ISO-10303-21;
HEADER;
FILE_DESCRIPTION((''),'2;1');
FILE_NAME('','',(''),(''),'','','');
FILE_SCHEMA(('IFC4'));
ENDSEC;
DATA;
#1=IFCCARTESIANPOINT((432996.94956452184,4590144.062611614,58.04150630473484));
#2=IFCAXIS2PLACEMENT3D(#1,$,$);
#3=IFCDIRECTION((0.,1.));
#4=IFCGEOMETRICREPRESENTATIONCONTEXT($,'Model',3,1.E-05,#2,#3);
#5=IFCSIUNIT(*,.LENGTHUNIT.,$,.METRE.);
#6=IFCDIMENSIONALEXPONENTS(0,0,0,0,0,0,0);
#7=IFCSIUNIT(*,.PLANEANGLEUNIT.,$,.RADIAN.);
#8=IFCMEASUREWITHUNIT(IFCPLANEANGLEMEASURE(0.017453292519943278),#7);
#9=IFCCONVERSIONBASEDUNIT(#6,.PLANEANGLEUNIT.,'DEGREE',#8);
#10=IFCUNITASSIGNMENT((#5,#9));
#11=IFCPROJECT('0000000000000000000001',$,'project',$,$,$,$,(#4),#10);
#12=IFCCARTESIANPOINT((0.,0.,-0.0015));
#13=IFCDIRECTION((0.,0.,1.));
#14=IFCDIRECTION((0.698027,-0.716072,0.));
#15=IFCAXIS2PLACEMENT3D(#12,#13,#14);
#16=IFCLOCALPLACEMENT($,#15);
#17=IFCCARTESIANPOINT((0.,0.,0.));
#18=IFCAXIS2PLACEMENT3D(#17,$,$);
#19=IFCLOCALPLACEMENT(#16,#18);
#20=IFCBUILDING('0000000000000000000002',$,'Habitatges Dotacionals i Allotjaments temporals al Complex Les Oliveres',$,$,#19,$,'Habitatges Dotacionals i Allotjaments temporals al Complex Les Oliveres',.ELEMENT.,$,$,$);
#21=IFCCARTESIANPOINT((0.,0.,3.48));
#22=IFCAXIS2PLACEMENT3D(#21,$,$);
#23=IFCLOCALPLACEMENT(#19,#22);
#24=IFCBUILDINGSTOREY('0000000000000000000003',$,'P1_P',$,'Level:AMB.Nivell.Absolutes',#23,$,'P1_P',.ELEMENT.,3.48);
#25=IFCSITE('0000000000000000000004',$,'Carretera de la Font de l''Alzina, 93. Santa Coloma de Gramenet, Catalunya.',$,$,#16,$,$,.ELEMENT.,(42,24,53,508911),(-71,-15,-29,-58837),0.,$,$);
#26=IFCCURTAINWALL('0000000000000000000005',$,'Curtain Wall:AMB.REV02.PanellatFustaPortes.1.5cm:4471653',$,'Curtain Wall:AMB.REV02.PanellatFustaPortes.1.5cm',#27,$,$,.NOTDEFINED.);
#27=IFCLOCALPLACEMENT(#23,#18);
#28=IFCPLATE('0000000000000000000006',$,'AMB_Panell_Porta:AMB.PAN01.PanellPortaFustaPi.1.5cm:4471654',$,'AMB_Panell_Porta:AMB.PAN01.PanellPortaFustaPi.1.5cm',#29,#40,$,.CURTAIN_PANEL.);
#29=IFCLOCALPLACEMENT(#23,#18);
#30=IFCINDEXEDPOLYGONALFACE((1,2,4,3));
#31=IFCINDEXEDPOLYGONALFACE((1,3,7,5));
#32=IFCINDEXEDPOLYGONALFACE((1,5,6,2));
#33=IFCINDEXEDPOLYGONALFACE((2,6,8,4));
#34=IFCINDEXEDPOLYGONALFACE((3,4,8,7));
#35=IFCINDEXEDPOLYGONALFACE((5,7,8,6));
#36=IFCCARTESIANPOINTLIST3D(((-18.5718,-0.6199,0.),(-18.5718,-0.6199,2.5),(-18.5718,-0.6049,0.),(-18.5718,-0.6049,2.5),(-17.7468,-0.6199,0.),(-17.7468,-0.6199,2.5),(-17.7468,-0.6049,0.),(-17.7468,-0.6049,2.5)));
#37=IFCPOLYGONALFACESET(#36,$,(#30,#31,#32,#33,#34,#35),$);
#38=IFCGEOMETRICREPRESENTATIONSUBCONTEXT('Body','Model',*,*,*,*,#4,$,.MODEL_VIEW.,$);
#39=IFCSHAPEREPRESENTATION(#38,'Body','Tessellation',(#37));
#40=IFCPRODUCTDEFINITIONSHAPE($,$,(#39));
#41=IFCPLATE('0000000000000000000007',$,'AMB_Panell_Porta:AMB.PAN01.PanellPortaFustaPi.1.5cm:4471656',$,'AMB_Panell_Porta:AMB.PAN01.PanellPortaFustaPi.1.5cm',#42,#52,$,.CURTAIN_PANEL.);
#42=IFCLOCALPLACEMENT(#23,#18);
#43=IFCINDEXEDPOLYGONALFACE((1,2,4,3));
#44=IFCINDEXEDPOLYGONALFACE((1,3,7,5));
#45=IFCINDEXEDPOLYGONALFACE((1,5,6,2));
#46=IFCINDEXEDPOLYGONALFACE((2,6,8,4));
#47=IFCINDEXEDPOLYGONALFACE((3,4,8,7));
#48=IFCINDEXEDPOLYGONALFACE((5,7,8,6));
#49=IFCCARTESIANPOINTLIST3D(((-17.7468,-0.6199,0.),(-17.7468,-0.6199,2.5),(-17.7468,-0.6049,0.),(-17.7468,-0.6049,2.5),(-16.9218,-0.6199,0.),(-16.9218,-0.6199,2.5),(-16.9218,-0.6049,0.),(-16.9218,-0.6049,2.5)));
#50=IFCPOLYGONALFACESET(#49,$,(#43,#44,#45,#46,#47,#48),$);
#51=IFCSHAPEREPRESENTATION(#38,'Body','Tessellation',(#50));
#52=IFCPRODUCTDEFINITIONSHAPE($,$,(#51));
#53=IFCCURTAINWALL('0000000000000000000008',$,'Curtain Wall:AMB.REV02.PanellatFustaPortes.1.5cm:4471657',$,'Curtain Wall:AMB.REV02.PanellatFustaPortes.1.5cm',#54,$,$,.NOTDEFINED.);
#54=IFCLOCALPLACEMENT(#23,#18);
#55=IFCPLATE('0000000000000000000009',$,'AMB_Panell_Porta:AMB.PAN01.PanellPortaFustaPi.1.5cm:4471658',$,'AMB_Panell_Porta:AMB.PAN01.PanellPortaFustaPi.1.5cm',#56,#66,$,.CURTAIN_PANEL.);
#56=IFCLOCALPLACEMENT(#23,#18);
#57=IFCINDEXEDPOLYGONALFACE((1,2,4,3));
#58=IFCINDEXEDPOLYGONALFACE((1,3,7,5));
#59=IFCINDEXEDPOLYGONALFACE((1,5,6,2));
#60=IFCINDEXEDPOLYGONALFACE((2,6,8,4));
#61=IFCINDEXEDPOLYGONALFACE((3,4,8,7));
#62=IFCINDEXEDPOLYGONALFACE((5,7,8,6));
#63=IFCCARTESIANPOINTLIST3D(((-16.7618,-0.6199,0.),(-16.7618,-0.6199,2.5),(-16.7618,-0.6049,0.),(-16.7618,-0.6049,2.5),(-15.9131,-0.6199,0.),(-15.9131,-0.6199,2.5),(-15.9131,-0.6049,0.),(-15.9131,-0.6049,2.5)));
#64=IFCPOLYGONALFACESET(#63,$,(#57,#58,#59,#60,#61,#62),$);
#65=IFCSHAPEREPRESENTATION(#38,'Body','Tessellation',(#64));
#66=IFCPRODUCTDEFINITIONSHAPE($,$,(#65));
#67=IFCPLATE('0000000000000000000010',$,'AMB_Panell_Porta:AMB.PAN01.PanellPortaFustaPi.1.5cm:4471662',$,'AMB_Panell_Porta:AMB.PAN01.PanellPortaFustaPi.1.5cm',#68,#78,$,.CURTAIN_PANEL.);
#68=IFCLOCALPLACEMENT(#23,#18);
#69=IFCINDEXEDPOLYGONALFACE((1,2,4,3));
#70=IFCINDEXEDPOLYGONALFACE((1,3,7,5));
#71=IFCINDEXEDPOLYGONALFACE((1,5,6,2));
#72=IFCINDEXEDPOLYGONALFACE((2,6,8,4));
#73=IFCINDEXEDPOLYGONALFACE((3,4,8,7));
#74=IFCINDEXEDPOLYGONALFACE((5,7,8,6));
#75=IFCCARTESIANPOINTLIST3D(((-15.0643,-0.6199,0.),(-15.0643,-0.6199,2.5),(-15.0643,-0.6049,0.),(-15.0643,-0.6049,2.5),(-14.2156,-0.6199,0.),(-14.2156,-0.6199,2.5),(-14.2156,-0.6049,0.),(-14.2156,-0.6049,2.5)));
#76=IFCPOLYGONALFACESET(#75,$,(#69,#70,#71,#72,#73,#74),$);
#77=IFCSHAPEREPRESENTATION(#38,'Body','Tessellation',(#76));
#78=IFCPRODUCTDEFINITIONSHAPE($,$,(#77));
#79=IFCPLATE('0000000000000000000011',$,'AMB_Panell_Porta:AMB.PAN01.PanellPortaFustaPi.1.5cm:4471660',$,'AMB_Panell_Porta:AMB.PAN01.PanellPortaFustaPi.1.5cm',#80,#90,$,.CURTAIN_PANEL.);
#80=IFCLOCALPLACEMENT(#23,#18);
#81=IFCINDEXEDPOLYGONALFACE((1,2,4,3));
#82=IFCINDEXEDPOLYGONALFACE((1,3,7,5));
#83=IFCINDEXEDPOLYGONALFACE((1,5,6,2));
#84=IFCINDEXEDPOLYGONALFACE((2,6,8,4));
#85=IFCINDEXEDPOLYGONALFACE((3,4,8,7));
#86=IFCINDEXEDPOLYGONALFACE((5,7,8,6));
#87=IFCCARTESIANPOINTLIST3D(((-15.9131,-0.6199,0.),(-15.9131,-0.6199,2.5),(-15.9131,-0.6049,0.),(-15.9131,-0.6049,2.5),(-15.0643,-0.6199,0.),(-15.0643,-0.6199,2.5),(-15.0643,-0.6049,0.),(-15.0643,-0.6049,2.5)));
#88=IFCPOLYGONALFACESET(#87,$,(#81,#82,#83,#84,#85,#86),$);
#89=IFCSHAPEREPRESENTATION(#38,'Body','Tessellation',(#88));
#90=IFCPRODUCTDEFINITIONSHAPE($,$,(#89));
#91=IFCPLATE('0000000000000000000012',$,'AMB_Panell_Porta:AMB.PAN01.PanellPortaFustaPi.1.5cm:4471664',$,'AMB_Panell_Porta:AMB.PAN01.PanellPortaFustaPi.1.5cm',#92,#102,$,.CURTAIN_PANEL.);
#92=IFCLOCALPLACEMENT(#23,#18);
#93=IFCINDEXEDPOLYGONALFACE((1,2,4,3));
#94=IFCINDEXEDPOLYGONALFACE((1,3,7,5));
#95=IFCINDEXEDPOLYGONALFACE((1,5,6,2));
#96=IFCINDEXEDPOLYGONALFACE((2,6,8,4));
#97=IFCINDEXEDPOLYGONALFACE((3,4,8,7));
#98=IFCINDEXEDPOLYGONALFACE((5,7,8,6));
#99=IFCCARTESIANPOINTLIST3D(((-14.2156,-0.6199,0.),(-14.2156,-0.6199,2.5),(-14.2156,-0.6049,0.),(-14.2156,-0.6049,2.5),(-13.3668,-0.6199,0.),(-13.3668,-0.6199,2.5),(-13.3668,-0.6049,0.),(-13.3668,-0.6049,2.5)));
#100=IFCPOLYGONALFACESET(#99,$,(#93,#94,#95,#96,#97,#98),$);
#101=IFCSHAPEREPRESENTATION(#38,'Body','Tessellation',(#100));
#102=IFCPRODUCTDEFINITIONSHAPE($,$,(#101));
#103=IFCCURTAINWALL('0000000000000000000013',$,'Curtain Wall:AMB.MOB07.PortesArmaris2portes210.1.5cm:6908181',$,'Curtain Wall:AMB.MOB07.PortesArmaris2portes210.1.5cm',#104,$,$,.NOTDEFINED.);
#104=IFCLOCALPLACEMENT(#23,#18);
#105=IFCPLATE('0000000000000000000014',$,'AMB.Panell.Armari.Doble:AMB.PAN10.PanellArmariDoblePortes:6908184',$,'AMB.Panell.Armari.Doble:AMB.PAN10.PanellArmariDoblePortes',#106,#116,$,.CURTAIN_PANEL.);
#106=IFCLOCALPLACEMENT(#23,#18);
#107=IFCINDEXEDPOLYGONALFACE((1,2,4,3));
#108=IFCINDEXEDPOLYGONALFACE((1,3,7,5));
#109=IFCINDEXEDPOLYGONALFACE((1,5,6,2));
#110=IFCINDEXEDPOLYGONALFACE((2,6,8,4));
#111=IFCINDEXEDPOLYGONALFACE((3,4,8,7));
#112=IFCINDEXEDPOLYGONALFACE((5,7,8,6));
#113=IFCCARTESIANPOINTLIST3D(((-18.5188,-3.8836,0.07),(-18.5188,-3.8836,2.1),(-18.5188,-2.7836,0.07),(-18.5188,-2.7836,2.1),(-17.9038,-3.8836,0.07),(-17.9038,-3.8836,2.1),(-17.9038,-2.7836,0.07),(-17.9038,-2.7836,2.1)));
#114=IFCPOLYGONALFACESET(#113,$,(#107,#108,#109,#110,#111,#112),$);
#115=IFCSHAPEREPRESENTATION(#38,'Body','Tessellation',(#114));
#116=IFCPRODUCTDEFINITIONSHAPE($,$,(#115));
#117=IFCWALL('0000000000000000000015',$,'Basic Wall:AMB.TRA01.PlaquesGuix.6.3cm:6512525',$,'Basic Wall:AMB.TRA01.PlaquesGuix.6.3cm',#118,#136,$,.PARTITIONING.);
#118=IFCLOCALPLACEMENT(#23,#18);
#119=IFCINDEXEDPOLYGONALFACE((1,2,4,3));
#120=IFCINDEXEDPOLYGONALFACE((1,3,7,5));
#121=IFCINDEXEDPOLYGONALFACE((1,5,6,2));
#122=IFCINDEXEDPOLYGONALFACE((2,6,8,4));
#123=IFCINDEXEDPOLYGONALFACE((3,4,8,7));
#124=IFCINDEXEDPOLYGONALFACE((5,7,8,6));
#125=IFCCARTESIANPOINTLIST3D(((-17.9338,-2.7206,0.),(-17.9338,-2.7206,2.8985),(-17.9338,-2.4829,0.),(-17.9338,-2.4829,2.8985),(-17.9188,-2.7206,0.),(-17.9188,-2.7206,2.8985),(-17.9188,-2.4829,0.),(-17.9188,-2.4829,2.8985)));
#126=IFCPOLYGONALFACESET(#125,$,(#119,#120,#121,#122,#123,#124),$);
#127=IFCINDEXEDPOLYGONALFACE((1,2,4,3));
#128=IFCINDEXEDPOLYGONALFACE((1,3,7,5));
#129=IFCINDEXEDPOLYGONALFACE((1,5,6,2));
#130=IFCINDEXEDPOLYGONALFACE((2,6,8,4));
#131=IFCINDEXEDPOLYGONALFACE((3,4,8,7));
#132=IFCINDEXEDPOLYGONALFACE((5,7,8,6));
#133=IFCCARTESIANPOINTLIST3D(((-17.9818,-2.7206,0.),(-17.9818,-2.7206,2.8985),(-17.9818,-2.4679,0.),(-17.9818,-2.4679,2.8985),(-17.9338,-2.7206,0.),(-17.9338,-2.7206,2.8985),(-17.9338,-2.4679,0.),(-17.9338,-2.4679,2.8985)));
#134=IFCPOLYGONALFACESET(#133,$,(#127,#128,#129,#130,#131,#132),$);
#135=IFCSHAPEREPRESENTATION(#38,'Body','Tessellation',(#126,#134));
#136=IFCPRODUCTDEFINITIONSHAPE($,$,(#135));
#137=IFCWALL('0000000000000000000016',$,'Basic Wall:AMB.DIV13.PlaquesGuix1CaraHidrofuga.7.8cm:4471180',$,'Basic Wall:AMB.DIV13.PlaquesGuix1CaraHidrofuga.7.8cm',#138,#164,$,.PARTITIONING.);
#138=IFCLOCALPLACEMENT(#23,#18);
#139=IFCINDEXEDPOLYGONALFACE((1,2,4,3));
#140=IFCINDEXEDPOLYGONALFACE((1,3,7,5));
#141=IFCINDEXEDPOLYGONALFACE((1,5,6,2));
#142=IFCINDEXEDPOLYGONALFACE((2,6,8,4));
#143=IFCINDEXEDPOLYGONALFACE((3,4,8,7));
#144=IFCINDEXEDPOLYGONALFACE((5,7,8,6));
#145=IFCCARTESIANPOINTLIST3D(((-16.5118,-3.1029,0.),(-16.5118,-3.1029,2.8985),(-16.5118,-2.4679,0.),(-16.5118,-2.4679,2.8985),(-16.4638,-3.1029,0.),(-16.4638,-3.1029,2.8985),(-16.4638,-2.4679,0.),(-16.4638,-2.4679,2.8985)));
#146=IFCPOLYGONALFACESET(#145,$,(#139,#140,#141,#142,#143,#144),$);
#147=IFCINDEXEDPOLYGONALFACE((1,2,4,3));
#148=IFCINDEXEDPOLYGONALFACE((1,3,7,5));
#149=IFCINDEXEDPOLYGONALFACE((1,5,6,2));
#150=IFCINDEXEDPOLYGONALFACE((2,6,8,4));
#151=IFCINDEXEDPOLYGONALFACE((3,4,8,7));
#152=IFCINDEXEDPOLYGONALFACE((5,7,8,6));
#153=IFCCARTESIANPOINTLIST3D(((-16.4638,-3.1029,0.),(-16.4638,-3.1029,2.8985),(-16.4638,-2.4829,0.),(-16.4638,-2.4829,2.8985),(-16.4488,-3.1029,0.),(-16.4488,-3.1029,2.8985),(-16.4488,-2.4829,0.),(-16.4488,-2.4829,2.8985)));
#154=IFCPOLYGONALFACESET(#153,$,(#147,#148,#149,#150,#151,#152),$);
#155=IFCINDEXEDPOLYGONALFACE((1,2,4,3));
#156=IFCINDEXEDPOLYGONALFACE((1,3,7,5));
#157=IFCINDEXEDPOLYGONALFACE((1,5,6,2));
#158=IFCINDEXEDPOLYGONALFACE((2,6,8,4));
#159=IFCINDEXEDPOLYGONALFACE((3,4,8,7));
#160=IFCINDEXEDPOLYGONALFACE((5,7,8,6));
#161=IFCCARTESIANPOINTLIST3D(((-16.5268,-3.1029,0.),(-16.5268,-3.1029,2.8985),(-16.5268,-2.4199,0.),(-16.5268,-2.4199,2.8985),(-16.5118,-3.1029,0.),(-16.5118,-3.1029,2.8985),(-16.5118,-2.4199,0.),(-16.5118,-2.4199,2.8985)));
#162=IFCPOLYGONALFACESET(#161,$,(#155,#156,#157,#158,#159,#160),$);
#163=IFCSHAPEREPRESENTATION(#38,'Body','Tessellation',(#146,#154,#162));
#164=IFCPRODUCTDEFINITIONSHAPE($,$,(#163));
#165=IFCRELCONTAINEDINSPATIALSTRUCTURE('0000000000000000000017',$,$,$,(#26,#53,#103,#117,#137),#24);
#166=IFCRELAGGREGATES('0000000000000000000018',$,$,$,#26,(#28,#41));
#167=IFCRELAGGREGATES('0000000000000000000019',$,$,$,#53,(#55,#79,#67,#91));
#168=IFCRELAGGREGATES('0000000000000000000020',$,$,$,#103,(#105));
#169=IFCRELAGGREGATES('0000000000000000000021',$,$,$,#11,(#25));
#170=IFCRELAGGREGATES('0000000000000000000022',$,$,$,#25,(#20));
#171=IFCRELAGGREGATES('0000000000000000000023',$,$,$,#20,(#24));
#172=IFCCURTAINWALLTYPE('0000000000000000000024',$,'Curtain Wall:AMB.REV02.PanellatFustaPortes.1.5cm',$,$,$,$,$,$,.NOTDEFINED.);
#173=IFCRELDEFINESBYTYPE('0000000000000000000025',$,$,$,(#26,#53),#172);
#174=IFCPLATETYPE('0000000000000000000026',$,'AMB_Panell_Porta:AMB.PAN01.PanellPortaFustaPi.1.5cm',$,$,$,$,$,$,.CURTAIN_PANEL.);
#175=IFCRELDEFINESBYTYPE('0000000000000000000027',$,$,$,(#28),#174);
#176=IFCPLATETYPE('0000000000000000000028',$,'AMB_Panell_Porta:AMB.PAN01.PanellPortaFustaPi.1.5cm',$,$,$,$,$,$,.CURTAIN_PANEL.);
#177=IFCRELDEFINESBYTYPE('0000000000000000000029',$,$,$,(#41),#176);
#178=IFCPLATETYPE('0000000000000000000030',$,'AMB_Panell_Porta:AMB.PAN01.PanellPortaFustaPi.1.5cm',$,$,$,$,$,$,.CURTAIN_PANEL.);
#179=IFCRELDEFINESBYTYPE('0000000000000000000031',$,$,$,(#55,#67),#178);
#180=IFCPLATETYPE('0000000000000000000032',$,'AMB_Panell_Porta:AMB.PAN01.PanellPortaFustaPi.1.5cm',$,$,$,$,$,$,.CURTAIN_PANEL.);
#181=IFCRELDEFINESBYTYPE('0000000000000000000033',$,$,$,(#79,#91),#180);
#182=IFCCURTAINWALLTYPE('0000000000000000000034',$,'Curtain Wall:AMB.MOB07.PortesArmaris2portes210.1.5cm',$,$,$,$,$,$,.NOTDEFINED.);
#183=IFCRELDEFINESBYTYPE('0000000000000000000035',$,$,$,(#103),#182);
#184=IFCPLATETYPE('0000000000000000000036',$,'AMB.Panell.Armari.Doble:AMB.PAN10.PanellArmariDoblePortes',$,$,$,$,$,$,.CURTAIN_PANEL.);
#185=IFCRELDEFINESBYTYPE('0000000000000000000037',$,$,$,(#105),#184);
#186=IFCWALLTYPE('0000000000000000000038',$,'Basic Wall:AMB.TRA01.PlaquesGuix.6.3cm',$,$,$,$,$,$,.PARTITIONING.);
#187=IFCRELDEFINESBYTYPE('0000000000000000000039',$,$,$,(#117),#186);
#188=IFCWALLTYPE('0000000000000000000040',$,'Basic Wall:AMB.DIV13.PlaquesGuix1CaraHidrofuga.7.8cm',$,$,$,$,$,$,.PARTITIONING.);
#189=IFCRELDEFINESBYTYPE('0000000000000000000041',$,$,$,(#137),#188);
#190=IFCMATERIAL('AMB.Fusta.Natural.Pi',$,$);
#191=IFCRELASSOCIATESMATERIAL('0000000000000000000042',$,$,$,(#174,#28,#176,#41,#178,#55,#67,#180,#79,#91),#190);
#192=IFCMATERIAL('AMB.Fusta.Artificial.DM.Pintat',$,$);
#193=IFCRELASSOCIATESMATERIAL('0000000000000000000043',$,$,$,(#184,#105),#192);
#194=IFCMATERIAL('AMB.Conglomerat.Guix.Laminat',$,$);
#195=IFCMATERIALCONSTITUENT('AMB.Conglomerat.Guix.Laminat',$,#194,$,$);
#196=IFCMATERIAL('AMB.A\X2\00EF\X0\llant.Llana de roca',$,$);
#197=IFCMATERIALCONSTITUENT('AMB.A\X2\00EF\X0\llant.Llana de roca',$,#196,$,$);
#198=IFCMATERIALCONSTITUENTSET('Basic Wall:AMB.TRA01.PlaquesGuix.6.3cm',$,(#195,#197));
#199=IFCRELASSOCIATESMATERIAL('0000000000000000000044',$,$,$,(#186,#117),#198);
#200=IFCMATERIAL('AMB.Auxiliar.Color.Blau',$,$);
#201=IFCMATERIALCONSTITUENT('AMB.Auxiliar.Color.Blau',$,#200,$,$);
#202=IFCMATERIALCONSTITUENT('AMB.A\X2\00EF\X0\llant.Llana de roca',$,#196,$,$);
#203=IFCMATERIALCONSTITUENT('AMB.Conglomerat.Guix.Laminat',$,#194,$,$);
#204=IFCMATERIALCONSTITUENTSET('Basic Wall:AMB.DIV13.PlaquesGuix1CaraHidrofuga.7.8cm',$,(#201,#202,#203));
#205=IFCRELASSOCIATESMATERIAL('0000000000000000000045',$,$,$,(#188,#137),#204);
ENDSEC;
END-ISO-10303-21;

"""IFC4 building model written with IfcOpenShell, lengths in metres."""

from ifc_helpers import new_model, entity, si_unit, converted_unit, direction, frame, origin, place, context, subcontext, project, spatial, indexed_curve, outline, extrude, source, transform, mapped, material, constituent, constituent_set, type_object, type_shapes, element, aggregate, save


model = new_model("IFC4")

# Units and contexts
model_context = context("Model", 3, precision=1e-05, world=frame((432996.94956452184, 4590144.062611614, 58.04150630473484)), true_north=direction((0.0, 1.0)))
body_context = subcontext(model_context, "Body", "Model", "MODEL_VIEW")
ifc_project = project(units=[si_unit("LENGTHUNIT", "METRE"), converted_unit("PLANEANGLEUNIT", "DEGREE", entity("IfcPlaneAngleMeasure", 0.017453292519943278), si_unit("PLANEANGLEUNIT", "RADIAN"), dimensions=[0, 0, 0, 0, 0, 0, 0])], contexts=[model_context])

# Site, building, storey
site_placement = place(None, frame((0.0, 0.0, -0.0015), z_axis=(0.0, 0.0, 1.0), x_axis=(0.698027, -0.716072, 0.0)))
site = spatial("IfcSite", under=ifc_project, at=site_placement, Name="Carretera de la Font de l'Alzina, 93. Santa Coloma de Gramenet, Catalunya.", CompositionType="ELEMENT", RefLatitude=(42, 24, 53, 508911), RefLongitude=(-71, -15, -29, -58837), RefElevation=0.0)
building_placement = place(site_placement, origin())
building = spatial("IfcBuilding", under=site, at=building_placement, Name="Habitatges Dotacionals i Allotjaments temporals al Complex Les Oliveres", LongName="Habitatges Dotacionals i Allotjaments temporals al Complex Les Oliveres", CompositionType="ELEMENT")
storey_placement = place(building_placement, frame((0.0, 0.0, 3.48)))
storey = spatial("IfcBuildingStorey", under=building, at=storey_placement, Name="P1_P", ObjectType="Level:AMB.Nivell.Absolutes", LongName="P1_P", CompositionType="ELEMENT", Elevation=3.48)

# Curtain walls, plates
curtain_wall_type_1 = type_object("IfcCurtainWallType", Name="Curtain Wall:AMB.REV02.PanellatFustaPortes.1.5cm", PredefinedType="NOTDEFINED")
curtain_wall_1_placement = place(storey_placement, frame((0.0, 0.0, -3.48)))
curtain_wall_1 = element("IfcCurtainWall", 1, at=curtain_wall_1_placement, inside=storey, type_object=curtain_wall_type_1, Name="Curtain Wall:AMB.REV02.PanellatFustaPortes.1.5cm:4471653", ObjectType="Curtain Wall:AMB.REV02.PanellatFustaPortes.1.5cm", PredefinedType="NOTDEFINED")
ifc_material_1 = material(Name="AMB.Fusta.Natural.Pi")
plate_type_1 = type_object("IfcPlateType", Name="AMB_Panell_Porta:AMB.PAN01.PanellPortaFustaPi.1.5cm", PredefinedType="CURTAIN_PANEL", material=ifc_material_1)
shared_shape_1 = source(origin(), body_context, "Body", "SweptSolid", [
    extrude(outline(indexed_curve([(-0.4125, -0.0075), (0.4125, -0.0075), (0.4125, 0.0075), (-0.4125, 0.0075), (-0.4125, -0.0075)], self_intersect=False)), frame((0.0, 0.0, 0.0), z_axis=(0.0, 0.0, 1.0), x_axis=(-1.0, 0.0, 0.0)), (0.0, 0.0, 1.0), 2.5),
])
type_shapes(plate_type_1, [shared_shape_1])
plate_1_placement = place(curtain_wall_1_placement, frame((-18.1593, -0.6124, 3.48), z_axis=(0.0, 0.0, 1.0), x_axis=(-1.0, 0.0, 0.0)))
plate_1 = element("IfcPlate", 2, at=plate_1_placement, type_object=plate_type_1, material=ifc_material_1, Name="AMB_Panell_Porta:AMB.PAN01.PanellPortaFustaPi.1.5cm:4471654", ObjectType="AMB_Panell_Porta:AMB.PAN01.PanellPortaFustaPi.1.5cm", PredefinedType="CURTAIN_PANEL", context=body_context, shape_type="MappedRepresentation", body=[
    mapped(shared_shape_1, transform((0.0, 0.0, 0.0), scale=1.0)),
])
plate_type_2 = type_object("IfcPlateType", Name="AMB_Panell_Porta:AMB.PAN01.PanellPortaFustaPi.1.5cm", PredefinedType="CURTAIN_PANEL", material=ifc_material_1)
shared_shape_2 = source(origin(), body_context, "Body", "SweptSolid", [
    extrude(outline(indexed_curve([(-0.0075, -0.4125), (0.0075, -0.4125), (0.0075, 0.4125), (-0.0075, 0.4125), (-0.0075, -0.4125)], self_intersect=False)), frame((0.0, 0.0, 0.0), z_axis=(0.0, 0.0, 1.0), x_axis=(0.0, 1.0, 0.0)), (0.0, 0.0, 1.0), 2.5),
])
type_shapes(plate_type_2, [shared_shape_2])
plate_2_placement = place(curtain_wall_1_placement, frame((-17.3343, -0.6124, 3.48)))
plate_2 = element("IfcPlate", 3, at=plate_2_placement, type_object=plate_type_2, material=ifc_material_1, Name="AMB_Panell_Porta:AMB.PAN01.PanellPortaFustaPi.1.5cm:4471656", ObjectType="AMB_Panell_Porta:AMB.PAN01.PanellPortaFustaPi.1.5cm", PredefinedType="CURTAIN_PANEL", context=body_context, shape_type="MappedRepresentation", body=[
    mapped(shared_shape_2, transform((0.0, 0.0, 0.0), scale=1.0)),
])
aggregate(curtain_wall_1, [plate_1, plate_2])
curtain_wall_2_placement = place(storey_placement, frame((0.0, 0.0, -3.48)))
curtain_wall_2 = element("IfcCurtainWall", 4, at=curtain_wall_2_placement, inside=storey, type_object=curtain_wall_type_1, Name="Curtain Wall:AMB.REV02.PanellatFustaPortes.1.5cm:4471657", ObjectType="Curtain Wall:AMB.REV02.PanellatFustaPortes.1.5cm", PredefinedType="NOTDEFINED")
plate_type_3 = type_object("IfcPlateType", Name="AMB_Panell_Porta:AMB.PAN01.PanellPortaFustaPi.1.5cm", PredefinedType="CURTAIN_PANEL", material=ifc_material_1)
shared_shape_3 = source(origin(), body_context, "Body", "SweptSolid", [
    extrude(outline(indexed_curve([(-0.4244, -0.0075), (0.4244, -0.0075), (0.4244, 0.0075), (-0.4244, 0.0075), (-0.4244, -0.0075)], self_intersect=False)), frame((0.0, 0.0, 0.0), z_axis=(0.0, 0.0, 1.0), x_axis=(-1.0, 0.0, 0.0)), (0.0, 0.0, 1.0), 2.5),
])
type_shapes(plate_type_3, [shared_shape_3])
plate_3_placement = place(curtain_wall_2_placement, frame((-16.3374, -0.6124, 3.48), z_axis=(0.0, 0.0, 1.0), x_axis=(-1.0, 0.0, 0.0)))
plate_3 = element("IfcPlate", 5, at=plate_3_placement, type_object=plate_type_3, material=ifc_material_1, Name="AMB_Panell_Porta:AMB.PAN01.PanellPortaFustaPi.1.5cm:4471658", ObjectType="AMB_Panell_Porta:AMB.PAN01.PanellPortaFustaPi.1.5cm", PredefinedType="CURTAIN_PANEL", context=body_context, shape_type="MappedRepresentation", body=[
    mapped(shared_shape_3, transform((0.0, 0.0, 0.0), scale=1.0)),
])
plate_4_placement = place(curtain_wall_2_placement, frame((-14.6399, -0.6124, 3.48), z_axis=(0.0, 0.0, 1.0), x_axis=(-1.0, 0.0, 0.0)))
plate_4 = element("IfcPlate", 6, at=plate_4_placement, type_object=plate_type_3, material=ifc_material_1, Name="AMB_Panell_Porta:AMB.PAN01.PanellPortaFustaPi.1.5cm:4471662", ObjectType="AMB_Panell_Porta:AMB.PAN01.PanellPortaFustaPi.1.5cm", PredefinedType="CURTAIN_PANEL", context=body_context, shape_type="MappedRepresentation", body=[
    mapped(shared_shape_3, transform((0.0, 0.0, 0.0), scale=1.0)),
])
plate_type_4 = type_object("IfcPlateType", Name="AMB_Panell_Porta:AMB.PAN01.PanellPortaFustaPi.1.5cm", PredefinedType="CURTAIN_PANEL", material=ifc_material_1)
shared_shape_4 = source(origin(), body_context, "Body", "SweptSolid", [
    extrude(outline(indexed_curve([(-0.0075, -0.4244), (0.0075, -0.4244), (0.0075, 0.4244), (-0.0075, 0.4244), (-0.0075, -0.4244)], self_intersect=False)), frame((0.0, 0.0, 0.0), z_axis=(0.0, 0.0, 1.0), x_axis=(0.0, 1.0, 0.0)), (0.0, 0.0, 1.0), 2.5),
])
type_shapes(plate_type_4, [shared_shape_4])
plate_5_placement = place(curtain_wall_2_placement, frame((-15.4887, -0.6124, 3.48)))
plate_5 = element("IfcPlate", 7, at=plate_5_placement, type_object=plate_type_4, material=ifc_material_1, Name="AMB_Panell_Porta:AMB.PAN01.PanellPortaFustaPi.1.5cm:4471660", ObjectType="AMB_Panell_Porta:AMB.PAN01.PanellPortaFustaPi.1.5cm", PredefinedType="CURTAIN_PANEL", context=body_context, shape_type="MappedRepresentation", body=[
    mapped(shared_shape_4, transform((0.0, 0.0, 0.0), scale=1.0)),
])
plate_6_placement = place(curtain_wall_2_placement, frame((-13.7912, -0.6124, 3.48)))
plate_6 = element("IfcPlate", 8, at=plate_6_placement, type_object=plate_type_4, material=ifc_material_1, Name="AMB_Panell_Porta:AMB.PAN01.PanellPortaFustaPi.1.5cm:4471664", ObjectType="AMB_Panell_Porta:AMB.PAN01.PanellPortaFustaPi.1.5cm", PredefinedType="CURTAIN_PANEL", context=body_context, shape_type="MappedRepresentation", body=[
    mapped(shared_shape_4, transform((0.0, 0.0, 0.0), scale=1.0)),
])
aggregate(curtain_wall_2, [plate_3, plate_5, plate_4, plate_6])

# Curtain wall, plate
curtain_wall_type_2 = type_object("IfcCurtainWallType", Name="Curtain Wall:AMB.MOB07.PortesArmaris2portes210.1.5cm", PredefinedType="NOTDEFINED")
curtain_wall_3_placement = place(storey_placement, frame((0.0, 0.0, -3.48)))
curtain_wall_3 = element("IfcCurtainWall", 9, at=curtain_wall_3_placement, inside=storey, type_object=curtain_wall_type_2, Name="Curtain Wall:AMB.MOB07.PortesArmaris2portes210.1.5cm:6908181", ObjectType="Curtain Wall:AMB.MOB07.PortesArmaris2portes210.1.5cm", PredefinedType="NOTDEFINED")
ifc_material_2 = material(Name="AMB.Fusta.Artificial.DM.Pintat")
plate_type_5 = type_object("IfcPlateType", Name="AMB.Panell.Armari.Doble:AMB.PAN10.PanellArmariDoblePortes", PredefinedType="CURTAIN_PANEL", material=ifc_material_2)
shared_shape_5 = source(origin(), body_context, "Body", "SweptSolid", [
    extrude(outline(indexed_curve([(-0.55, -0.3075), (0.55, -0.3075), (0.55, 0.3075), (-0.55, 0.3075), (-0.55, -0.3075)], self_intersect=False)), frame((0.0, -0.3075, 0.0), z_axis=(0.0, 0.0, 1.0), x_axis=(-1.0, 0.0, 0.0)), (0.0, 0.0, 1.0), 2.03),
])
type_shapes(plate_type_5, [shared_shape_5])
plate_7_placement = place(curtain_wall_3_placement, frame((-17.9038, -3.3336, 3.55), z_axis=(0.0, 0.0, 1.0), x_axis=(0.0, -1.0, 0.0)))
plate_7 = element("IfcPlate", 10, at=plate_7_placement, type_object=plate_type_5, material=ifc_material_2, Name="AMB.Panell.Armari.Doble:AMB.PAN10.PanellArmariDoblePortes:6908184", ObjectType="AMB.Panell.Armari.Doble:AMB.PAN10.PanellArmariDoblePortes", PredefinedType="CURTAIN_PANEL", context=body_context, shape_type="MappedRepresentation", body=[
    mapped(shared_shape_5, transform((0.0, 0.0, 0.0), scale=1.0)),
])

# Shared definitions
ifc_material_3 = material(Name="AMB.Conglomerat.Guix.Laminat")
ifc_constituent_1 = constituent(ifc_material_3, Name="AMB.Conglomerat.Guix.Laminat")
ifc_material_4 = material(Name="AMB.Aïllant.Llana de roca")
ifc_constituent_2 = constituent(ifc_material_4, Name="AMB.Aïllant.Llana de roca")
ifc_constituent_set_1 = constituent_set(constituents=[ifc_constituent_1, ifc_constituent_2], Name="Basic Wall:AMB.TRA01.PlaquesGuix.6.3cm")
wall_type_1 = type_object("IfcWallType", Name="Basic Wall:AMB.TRA01.PlaquesGuix.6.3cm", PredefinedType="PARTITIONING", material=ifc_constituent_set_1)

# Walls
wall_1_placement = place(storey_placement, frame((-17.9503, -2.4829, 0.0), z_axis=(0.0, 0.0, 1.0), x_axis=(0.0, -1.0, 0.0)))
element("IfcWall", 11, at=wall_1_placement, inside=storey, type_object=wall_type_1, material=ifc_constituent_set_1, Name="Basic Wall:AMB.TRA01.PlaquesGuix.6.3cm:6512525", ObjectType="Basic Wall:AMB.TRA01.PlaquesGuix.6.3cm", PredefinedType="PARTITIONING", context=body_context, shape_type="SweptSolid", body=[
    extrude(outline(indexed_curve([(-0.0075, -0.1189), (0.0075, -0.1189), (0.0075, 0.1189), (-0.0075, 0.1189), (-0.0075, -0.1189)], self_intersect=False)), frame((0.1189, 0.024, 0.0), z_axis=(0.0, 0.0, 1.0), x_axis=(0.0, -1.0, 0.0)), (0.0, 0.0, 1.0), 2.8985),
    extrude(outline(indexed_curve([(-0.024, -0.1264), (0.024, -0.1264), (0.024, 0.1264), (-0.024, 0.1264), (-0.024, -0.1264)], self_intersect=False)), frame((0.1114, -0.0075, 0.0), z_axis=(0.0, 0.0, 1.0), x_axis=(0.0, 1.0, 0.0)), (0.0, 0.0, 1.0), 2.8985),
])
ifc_material_5 = material(Name="AMB.Auxiliar.Color.Blau")
ifc_constituent_3 = constituent(ifc_material_5, Name="AMB.Auxiliar.Color.Blau")
ifc_constituent_4 = constituent(ifc_material_4, Name="AMB.Aïllant.Llana de roca")
ifc_constituent_5 = constituent(ifc_material_3, Name="AMB.Conglomerat.Guix.Laminat")
ifc_constituent_set_2 = constituent_set(constituents=[ifc_constituent_3, ifc_constituent_4, ifc_constituent_5], Name="Basic Wall:AMB.DIV13.PlaquesGuix1CaraHidrofuga.7.8cm")
wall_type_2 = type_object("IfcWallType", Name="Basic Wall:AMB.DIV13.PlaquesGuix1CaraHidrofuga.7.8cm", PredefinedType="PARTITIONING", material=ifc_constituent_set_2)
wall_2_placement = place(storey_placement, frame((-16.4878, -3.1029, 0.0), z_axis=(0.0, 0.0, 1.0), x_axis=(0.0, 1.0, 0.0)))
element("IfcWall", 12, at=wall_2_placement, inside=storey, type_object=wall_type_2, material=ifc_constituent_set_2, Name="Basic Wall:AMB.DIV13.PlaquesGuix1CaraHidrofuga.7.8cm:4471180", ObjectType="Basic Wall:AMB.DIV13.PlaquesGuix1CaraHidrofuga.7.8cm", PredefinedType="PARTITIONING", context=body_context, shape_type="SweptSolid", body=[
    extrude(outline(indexed_curve([(-0.3175, -0.024), (0.3175, -0.024), (0.3175, 0.024), (-0.3175, 0.024), (-0.3175, -0.024)], self_intersect=False)), frame((0.3175, 0.0, 0.0)), (0.0, 0.0, 1.0), 2.8985),
    extrude(outline(indexed_curve([(-0.0075, -0.31), (0.0075, -0.31), (0.0075, 0.31), (-0.0075, 0.31), (-0.0075, -0.31)], self_intersect=False)), frame((0.31, -0.0315, 0.0), z_axis=(0.0, 0.0, 1.0), x_axis=(0.0, 1.0, 0.0)), (0.0, 0.0, 1.0), 2.8985),
    extrude(outline(indexed_curve([(-0.0075, -0.3415), (0.0075, -0.3415), (0.0075, 0.3415), (-0.0075, 0.3415), (-0.0075, -0.3415)], self_intersect=False)), frame((0.3415, 0.0315, 0.0), z_axis=(0.0, 0.0, 1.0), x_axis=(0.0, -1.0, 0.0)), (0.0, 0.0, 1.0), 2.8985),
])

aggregate(curtain_wall_3, [plate_7])

save(model, "model.ifc")
